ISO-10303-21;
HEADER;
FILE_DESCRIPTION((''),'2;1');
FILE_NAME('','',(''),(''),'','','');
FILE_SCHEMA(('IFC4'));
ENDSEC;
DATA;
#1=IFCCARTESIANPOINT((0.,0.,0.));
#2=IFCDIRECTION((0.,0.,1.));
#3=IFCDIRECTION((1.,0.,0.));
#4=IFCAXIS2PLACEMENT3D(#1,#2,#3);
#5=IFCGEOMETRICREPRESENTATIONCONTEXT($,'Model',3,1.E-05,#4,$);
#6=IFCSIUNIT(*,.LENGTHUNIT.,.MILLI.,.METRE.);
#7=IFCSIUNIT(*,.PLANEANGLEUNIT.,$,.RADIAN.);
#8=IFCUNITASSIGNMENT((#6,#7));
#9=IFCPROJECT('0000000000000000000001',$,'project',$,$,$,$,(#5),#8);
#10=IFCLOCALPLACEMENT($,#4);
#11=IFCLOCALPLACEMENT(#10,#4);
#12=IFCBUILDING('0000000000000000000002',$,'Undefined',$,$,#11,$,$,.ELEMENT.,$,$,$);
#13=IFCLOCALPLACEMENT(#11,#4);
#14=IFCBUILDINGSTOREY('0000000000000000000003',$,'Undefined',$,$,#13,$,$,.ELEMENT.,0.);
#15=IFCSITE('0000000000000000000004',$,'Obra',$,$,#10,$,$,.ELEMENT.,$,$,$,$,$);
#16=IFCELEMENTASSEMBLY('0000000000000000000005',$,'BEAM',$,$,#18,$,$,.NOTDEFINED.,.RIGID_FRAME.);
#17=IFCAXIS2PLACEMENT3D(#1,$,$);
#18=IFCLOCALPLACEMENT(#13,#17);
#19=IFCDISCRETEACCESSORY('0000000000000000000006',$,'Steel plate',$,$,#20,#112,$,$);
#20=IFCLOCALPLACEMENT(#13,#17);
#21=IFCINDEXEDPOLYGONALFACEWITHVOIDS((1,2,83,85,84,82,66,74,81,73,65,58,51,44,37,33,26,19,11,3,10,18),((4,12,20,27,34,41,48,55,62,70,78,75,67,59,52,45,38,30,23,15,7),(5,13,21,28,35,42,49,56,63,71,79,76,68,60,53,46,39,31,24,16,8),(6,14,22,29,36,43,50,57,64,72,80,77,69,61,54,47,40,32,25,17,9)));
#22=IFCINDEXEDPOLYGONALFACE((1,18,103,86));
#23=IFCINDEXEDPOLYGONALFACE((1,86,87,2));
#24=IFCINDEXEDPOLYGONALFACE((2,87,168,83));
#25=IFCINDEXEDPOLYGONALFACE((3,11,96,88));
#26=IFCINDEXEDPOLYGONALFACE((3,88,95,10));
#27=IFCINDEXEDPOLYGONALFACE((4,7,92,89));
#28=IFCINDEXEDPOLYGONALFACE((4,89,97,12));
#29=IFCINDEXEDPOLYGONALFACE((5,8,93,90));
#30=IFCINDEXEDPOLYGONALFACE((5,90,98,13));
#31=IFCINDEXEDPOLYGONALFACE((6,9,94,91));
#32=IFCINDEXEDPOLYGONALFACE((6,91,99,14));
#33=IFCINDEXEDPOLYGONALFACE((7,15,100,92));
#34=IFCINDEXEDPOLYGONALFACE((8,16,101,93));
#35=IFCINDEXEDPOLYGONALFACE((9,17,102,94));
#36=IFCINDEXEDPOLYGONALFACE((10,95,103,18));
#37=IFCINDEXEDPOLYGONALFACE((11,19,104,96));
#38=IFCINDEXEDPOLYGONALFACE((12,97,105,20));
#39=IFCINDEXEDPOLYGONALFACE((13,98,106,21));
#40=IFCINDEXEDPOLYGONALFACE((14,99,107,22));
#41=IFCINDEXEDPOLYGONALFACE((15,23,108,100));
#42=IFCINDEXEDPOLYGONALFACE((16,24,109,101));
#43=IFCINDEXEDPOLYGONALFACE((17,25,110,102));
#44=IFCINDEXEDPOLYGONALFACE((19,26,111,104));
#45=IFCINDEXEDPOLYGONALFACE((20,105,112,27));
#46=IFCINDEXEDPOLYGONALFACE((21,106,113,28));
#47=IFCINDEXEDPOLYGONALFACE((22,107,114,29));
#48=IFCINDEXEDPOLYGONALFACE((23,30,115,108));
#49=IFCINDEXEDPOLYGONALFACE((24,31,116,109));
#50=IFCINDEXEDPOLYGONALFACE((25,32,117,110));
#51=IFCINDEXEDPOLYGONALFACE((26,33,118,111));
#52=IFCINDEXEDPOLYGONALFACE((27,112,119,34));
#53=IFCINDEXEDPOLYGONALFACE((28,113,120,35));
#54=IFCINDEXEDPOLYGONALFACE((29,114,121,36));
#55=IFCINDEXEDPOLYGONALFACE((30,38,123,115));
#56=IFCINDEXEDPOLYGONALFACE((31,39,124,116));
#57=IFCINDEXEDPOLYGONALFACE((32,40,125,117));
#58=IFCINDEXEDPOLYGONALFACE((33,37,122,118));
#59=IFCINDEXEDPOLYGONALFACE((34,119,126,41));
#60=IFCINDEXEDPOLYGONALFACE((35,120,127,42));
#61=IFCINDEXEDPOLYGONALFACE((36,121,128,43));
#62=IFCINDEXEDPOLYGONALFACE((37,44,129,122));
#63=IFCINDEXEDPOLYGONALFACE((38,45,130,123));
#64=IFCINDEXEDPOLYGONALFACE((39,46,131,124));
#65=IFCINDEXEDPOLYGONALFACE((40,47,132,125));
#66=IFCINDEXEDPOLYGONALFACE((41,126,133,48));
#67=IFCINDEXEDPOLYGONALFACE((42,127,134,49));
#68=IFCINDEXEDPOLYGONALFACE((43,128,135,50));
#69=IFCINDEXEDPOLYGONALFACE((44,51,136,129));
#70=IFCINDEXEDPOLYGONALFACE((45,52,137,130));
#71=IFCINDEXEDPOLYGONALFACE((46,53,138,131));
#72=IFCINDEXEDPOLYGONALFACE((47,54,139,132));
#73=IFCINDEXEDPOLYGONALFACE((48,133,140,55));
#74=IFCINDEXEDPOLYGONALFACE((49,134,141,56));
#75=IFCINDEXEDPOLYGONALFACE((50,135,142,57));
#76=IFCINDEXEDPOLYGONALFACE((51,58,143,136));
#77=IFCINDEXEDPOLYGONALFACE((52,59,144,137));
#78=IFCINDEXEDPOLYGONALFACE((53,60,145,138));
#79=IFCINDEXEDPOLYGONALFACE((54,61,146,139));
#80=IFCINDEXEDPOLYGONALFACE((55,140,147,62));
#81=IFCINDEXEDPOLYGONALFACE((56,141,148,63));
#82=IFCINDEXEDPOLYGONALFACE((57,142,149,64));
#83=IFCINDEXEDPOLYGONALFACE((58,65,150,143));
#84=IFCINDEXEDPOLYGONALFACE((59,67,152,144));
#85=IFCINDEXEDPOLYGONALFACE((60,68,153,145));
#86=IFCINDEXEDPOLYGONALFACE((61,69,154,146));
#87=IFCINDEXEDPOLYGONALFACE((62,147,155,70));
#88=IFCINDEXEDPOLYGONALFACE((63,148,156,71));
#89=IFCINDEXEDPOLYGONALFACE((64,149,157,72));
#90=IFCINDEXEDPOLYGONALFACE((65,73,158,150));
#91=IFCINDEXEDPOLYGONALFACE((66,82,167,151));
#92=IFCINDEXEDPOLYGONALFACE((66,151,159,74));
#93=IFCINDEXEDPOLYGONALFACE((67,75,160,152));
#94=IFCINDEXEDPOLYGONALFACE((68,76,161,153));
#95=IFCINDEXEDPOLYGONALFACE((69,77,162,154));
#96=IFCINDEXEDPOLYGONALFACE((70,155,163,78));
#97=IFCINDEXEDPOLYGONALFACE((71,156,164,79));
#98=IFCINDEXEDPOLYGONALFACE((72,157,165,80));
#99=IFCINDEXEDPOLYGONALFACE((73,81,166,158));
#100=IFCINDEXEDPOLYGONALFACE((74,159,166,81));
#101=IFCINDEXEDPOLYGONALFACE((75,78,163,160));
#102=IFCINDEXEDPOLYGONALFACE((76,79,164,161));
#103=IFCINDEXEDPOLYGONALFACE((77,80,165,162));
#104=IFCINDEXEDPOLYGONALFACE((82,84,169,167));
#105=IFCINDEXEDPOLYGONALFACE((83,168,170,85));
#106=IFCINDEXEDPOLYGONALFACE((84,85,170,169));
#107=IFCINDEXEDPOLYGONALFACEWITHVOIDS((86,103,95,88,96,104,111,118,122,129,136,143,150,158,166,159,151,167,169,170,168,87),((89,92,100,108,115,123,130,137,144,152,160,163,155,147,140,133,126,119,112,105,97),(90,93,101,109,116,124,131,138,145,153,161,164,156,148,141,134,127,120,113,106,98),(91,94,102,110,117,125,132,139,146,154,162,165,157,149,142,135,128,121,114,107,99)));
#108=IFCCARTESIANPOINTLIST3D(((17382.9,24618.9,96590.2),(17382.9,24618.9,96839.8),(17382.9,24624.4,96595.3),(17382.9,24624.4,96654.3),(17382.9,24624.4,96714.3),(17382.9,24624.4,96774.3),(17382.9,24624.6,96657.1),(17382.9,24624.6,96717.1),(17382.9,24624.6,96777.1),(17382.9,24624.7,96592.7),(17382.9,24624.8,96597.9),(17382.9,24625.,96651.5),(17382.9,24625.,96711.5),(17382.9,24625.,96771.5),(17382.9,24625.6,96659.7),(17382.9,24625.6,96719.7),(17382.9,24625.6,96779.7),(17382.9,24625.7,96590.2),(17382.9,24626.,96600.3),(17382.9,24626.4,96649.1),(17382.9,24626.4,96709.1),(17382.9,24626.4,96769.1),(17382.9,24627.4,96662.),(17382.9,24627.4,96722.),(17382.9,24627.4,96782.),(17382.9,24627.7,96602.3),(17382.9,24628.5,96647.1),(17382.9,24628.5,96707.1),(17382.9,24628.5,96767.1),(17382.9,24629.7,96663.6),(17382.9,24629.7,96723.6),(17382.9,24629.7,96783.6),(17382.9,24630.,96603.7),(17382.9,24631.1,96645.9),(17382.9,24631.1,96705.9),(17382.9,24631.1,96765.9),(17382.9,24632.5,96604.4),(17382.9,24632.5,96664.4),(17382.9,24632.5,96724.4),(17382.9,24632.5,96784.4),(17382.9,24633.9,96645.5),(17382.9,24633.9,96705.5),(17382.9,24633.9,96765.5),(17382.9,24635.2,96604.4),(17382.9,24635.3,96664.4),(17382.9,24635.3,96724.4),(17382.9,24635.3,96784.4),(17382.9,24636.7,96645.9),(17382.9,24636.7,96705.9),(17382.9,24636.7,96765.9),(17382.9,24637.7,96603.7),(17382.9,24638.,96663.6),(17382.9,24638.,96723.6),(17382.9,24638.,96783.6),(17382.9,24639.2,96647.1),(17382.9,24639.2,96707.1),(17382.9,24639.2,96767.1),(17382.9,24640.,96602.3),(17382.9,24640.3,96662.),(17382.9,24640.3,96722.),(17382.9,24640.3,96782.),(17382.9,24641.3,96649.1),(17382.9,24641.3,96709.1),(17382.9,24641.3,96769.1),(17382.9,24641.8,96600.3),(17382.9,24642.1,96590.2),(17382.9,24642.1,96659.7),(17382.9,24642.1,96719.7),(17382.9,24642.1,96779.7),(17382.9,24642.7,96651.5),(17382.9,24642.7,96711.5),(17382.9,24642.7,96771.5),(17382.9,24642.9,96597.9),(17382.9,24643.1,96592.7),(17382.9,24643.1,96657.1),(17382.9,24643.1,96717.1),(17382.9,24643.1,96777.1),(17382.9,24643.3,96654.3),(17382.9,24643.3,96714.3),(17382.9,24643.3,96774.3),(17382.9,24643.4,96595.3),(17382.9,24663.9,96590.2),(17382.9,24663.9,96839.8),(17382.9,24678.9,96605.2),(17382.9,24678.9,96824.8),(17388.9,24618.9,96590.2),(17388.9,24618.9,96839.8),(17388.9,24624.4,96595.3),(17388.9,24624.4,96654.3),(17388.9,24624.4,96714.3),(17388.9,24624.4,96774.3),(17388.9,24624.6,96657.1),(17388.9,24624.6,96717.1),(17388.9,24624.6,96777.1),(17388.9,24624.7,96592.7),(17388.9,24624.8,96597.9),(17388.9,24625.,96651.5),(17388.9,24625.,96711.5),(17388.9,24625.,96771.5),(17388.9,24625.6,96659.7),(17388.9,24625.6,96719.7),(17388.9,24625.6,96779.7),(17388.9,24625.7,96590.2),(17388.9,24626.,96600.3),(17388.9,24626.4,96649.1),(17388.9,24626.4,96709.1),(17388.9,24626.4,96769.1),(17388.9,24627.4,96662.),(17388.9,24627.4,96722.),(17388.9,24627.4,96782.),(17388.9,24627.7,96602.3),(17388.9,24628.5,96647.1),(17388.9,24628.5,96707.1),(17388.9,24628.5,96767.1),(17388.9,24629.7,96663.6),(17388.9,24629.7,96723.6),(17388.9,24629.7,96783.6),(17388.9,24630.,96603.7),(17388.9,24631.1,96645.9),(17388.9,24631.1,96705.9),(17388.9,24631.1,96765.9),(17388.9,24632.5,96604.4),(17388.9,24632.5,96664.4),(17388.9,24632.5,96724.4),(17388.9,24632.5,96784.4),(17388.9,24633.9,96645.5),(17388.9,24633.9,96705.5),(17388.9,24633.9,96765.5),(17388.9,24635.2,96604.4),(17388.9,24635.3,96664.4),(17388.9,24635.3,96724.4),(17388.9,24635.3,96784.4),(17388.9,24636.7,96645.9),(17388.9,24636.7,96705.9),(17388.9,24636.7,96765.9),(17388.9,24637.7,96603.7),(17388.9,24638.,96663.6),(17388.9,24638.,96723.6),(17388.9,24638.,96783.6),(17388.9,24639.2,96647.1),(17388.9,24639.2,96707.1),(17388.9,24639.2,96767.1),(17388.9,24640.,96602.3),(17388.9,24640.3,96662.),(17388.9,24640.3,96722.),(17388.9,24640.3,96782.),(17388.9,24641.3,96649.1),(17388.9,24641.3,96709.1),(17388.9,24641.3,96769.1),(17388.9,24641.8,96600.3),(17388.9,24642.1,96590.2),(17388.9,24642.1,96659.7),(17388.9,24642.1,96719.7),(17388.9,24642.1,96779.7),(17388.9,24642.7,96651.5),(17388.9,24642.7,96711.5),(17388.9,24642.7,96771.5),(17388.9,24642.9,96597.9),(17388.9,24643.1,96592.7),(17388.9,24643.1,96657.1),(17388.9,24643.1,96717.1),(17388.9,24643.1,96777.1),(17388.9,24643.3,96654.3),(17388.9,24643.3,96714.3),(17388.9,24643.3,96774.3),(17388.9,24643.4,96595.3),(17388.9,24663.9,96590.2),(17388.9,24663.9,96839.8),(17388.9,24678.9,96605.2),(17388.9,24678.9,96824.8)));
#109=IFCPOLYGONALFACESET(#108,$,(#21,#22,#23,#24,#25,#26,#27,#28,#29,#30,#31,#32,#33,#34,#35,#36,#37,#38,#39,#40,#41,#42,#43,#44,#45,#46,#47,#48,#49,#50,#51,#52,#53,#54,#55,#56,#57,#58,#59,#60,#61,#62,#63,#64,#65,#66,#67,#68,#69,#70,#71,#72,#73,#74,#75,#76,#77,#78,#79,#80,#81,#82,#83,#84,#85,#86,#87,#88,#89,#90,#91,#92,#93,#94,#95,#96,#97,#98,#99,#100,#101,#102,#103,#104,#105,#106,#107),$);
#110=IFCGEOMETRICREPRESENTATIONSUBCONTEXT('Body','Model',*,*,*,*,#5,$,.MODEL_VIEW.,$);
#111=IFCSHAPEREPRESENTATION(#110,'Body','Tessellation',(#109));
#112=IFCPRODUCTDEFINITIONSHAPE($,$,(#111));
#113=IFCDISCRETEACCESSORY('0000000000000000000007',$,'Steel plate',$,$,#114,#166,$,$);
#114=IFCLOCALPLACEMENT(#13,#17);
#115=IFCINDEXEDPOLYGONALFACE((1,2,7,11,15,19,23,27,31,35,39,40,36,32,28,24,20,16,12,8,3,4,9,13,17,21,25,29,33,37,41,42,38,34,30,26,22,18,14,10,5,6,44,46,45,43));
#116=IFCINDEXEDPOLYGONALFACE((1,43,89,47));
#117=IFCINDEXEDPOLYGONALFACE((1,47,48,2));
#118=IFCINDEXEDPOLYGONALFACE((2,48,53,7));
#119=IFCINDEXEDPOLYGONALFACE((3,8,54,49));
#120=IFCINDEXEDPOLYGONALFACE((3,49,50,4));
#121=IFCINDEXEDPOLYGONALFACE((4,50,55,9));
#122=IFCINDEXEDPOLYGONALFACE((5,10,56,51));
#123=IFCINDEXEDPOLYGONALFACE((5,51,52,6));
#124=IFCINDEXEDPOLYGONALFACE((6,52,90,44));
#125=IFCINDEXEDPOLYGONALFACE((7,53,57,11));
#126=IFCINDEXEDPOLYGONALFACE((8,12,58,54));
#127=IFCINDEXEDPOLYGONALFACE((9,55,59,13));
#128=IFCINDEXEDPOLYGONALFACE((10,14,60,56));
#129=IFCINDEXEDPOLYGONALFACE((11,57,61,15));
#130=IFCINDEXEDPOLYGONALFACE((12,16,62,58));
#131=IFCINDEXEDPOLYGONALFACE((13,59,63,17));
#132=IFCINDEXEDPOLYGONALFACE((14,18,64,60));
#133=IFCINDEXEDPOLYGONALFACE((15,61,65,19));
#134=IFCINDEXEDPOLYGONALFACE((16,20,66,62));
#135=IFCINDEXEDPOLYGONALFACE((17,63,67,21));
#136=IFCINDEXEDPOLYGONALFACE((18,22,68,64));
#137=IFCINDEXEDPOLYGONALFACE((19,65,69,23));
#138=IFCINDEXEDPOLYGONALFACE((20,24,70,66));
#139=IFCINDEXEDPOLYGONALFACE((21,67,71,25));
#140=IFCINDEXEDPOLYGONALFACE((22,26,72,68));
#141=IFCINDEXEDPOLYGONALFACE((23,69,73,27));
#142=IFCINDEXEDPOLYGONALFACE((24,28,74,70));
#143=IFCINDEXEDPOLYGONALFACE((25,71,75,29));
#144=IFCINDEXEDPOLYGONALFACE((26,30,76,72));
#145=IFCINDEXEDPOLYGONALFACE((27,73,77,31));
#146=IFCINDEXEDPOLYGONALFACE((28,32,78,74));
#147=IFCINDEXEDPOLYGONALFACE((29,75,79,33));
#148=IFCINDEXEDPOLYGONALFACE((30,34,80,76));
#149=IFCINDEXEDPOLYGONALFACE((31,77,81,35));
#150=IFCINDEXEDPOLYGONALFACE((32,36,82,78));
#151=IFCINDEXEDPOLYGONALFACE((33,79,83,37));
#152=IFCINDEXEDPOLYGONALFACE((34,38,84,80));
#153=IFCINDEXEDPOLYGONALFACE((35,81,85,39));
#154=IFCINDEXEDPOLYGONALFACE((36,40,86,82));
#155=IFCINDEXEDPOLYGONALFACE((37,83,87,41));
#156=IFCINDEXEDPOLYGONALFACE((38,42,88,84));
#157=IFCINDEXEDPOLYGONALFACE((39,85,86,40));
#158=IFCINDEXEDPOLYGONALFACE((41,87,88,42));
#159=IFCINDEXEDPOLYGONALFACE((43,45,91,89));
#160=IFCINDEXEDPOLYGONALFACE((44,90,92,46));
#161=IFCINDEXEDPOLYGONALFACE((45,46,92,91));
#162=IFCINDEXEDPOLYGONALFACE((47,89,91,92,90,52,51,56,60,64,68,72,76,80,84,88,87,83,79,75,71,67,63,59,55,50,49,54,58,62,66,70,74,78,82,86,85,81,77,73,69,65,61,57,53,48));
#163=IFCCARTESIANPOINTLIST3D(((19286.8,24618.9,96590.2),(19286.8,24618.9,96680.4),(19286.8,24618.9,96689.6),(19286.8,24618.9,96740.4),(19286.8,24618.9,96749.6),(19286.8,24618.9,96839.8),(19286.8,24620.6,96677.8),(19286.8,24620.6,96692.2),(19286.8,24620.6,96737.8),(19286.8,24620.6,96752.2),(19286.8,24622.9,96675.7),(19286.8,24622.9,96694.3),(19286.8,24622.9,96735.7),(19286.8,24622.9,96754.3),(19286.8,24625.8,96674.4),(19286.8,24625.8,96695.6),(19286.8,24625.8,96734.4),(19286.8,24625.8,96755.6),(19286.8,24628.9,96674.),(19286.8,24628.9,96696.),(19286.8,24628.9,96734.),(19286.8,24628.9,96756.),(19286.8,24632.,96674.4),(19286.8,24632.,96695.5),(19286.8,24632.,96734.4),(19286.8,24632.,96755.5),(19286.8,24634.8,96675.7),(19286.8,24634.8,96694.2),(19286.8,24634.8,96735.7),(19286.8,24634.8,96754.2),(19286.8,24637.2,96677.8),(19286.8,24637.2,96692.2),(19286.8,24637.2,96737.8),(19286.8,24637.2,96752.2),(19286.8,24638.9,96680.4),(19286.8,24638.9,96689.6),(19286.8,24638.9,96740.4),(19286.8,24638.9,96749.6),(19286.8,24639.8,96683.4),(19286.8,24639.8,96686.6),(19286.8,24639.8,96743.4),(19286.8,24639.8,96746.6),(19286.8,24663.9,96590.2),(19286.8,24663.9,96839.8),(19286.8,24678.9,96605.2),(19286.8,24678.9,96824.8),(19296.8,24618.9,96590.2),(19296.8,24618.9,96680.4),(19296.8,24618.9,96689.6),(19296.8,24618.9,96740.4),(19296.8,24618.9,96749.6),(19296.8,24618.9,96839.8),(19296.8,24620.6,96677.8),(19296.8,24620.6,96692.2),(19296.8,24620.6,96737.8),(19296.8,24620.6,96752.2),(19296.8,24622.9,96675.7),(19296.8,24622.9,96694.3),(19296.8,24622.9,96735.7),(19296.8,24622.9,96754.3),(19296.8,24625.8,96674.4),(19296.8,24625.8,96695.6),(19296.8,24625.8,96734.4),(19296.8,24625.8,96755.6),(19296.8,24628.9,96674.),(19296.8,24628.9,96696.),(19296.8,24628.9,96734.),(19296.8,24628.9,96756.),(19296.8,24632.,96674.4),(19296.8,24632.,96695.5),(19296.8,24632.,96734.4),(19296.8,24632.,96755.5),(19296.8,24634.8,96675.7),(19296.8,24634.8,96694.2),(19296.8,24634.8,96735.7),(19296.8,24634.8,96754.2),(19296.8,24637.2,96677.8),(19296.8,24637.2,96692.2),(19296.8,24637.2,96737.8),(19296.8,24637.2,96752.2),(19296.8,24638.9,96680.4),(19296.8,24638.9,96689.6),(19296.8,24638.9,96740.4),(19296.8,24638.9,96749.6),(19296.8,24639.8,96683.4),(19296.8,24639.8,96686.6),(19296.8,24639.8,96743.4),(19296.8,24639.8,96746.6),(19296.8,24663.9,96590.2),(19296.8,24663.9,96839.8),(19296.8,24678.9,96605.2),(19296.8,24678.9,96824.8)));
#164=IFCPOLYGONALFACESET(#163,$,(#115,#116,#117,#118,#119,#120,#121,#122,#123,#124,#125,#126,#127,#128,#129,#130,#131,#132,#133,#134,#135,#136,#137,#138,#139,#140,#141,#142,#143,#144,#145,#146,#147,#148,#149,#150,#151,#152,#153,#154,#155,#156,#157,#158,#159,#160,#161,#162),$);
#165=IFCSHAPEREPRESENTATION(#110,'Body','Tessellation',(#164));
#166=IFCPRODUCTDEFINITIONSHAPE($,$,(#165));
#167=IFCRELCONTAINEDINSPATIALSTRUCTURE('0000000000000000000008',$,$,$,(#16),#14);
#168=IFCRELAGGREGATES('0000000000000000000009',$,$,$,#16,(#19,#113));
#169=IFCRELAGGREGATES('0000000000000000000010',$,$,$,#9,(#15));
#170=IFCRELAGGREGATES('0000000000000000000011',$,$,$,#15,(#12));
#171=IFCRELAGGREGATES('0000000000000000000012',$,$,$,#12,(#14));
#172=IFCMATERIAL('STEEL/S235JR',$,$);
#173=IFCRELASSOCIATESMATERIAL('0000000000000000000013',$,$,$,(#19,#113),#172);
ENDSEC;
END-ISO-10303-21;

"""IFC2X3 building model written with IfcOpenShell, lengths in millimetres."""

from ifc_helpers import new_model, si_unit, frame, origin_with_axes, origin_2d_with_axis, place, context, subcontext, project, spatial, polyline, circle, outline, extrude, source, transform, mapped, material, element, aggregate, save


model = new_model("IFC2X3")

# Units and contexts
model_context = context("Model", 3, precision=1e-05, world=origin_with_axes())
body_context = subcontext(model_context, "Body", "Model", "MODEL_VIEW")
ifc_project = project(units=[si_unit("LENGTHUNIT", "METRE", prefix="MILLI"), si_unit("PLANEANGLEUNIT", "RADIAN")], contexts=[model_context])

# Site, building, storey
site_placement = place(None, origin_with_axes())
site = spatial("IfcSite", under=ifc_project, at=site_placement, Name="Obra", CompositionType="ELEMENT")
building_placement = place(site_placement, origin_with_axes())
building = spatial("IfcBuilding", under=site, at=building_placement, Name="Undefined", CompositionType="ELEMENT")
storey_placement = place(building_placement, origin_with_axes())
storey = spatial("IfcBuildingStorey", under=building, at=storey_placement, Name="Undefined", CompositionType="ELEMENT", Elevation=0.0)

# Shared definitions
ifc_material = material(Name="STEEL/S235JR")

# Shared definitions
shared_shape_1 = source(origin_with_axes(), body_context, "Body", "SweptSolid", [
    extrude(circle(Radius=11.0, at=origin_2d_with_axis()), frame((0.0, -13.4, 0.0), z_axis=(0.0, 1.0, 0.0), x_axis=(1.0, 0.0, 0.0)), (0.0, 0.0, 1.0), 10.2),
])

# Element assembly, discrete accessories, openings
assembly_1_placement = place(storey_placement, origin_with_axes())
assembly_1 = element("IfcElementAssembly", 1, at=assembly_1_placement, inside=storey, Name="BEAM", AssemblyPlace="NOTDEFINED", PredefinedType="RIGID_FRAME")
discrete_accessory_1_placement = place(assembly_1_placement, frame((17385.9, 24618.9, 96590.2), z_axis=(1.0, 0.000001, 0.0), x_axis=(-0.000002, 1.0, 0.0)))
discrete_accessory_1 = element("IfcDiscreteAccessory", 2, at=discrete_accessory_1_placement, material=ifc_material, Name="Steel plate", context=body_context, shape_type="SweptSolid", body=[
    extrude(outline(polyline([(0.0, 0.0), (45.0, 0.0), (60.0, 15.0), (60.0, 234.6), (45.0, 249.6), (0.0, 249.6), (0.0, 0.0)])), frame((0.0, 0.0, -3.0), z_axis=(0.0, 0.0, 1.0), x_axis=(1.0, 0.0, 0.0)), (0.0, 0.0, 1.0), 6.0),
])
shared_shape_2 = source(origin_with_axes(), body_context, "Body", "SweptSolid", [
    extrude(circle(Radius=9.5, at=origin_2d_with_axis()), frame((0.0, -9.8, 0.0), z_axis=(0.0, 1.0, 0.0), x_axis=(1.0, 0.0, 0.0)), (0.0, 0.0, 1.0), 6.2),
])
opening_1_placement = place(assembly_1_placement, frame((17392.7, 24668.9, 96850.0), z_axis=(0.000002, -1.0, 0.0), x_axis=(0.0, 0.0, -1.0)))
element("IfcOpeningElement", 3, at=opening_1_placement, cuts=discrete_accessory_1, ObjectType="Opening", context=body_context, shape_type="MappedRepresentation", body=[
    mapped(shared_shape_2, transform((75.0, 0.0, 35.0))),
    mapped(shared_shape_2, transform((135.0, 0.0, 35.0))),
    mapped(shared_shape_2, transform((195.0, 0.0, 35.0))),
    mapped(shared_shape_2, transform((255.0, 0.0, 35.0))),
])
discrete_accessory_2_placement = place(assembly_1_placement, frame((19291.8, 24618.9, 96590.2), z_axis=(1.0, 0.000001, 0.0), x_axis=(-0.000002, 1.0, 0.0)))
discrete_accessory_2 = element("IfcDiscreteAccessory", 4, at=discrete_accessory_2_placement, material=ifc_material, Name="Steel plate", context=body_context, shape_type="SweptSolid", body=[
    extrude(outline(polyline([(0.0, 0.0), (45.0, 0.0), (60.0, 15.0), (60.0, 234.6), (45.0, 249.6), (0.0, 249.6), (0.0, 0.0)])), frame((0.0, 0.0, -5.0), z_axis=(0.0, 0.0, 1.0), x_axis=(1.0, 0.0, 0.0)), (0.0, 0.0, 1.0), 10.0),
])
opening_2_placement = place(assembly_1_placement, frame((19300.1, 24668.9, 96850.0), z_axis=(0.000002, -1.0, 0.0), x_axis=(0.0, 0.0, -1.0)))
element("IfcOpeningElement", 5, at=opening_2_placement, cuts=discrete_accessory_2, ObjectType="Opening", context=body_context, shape_type="MappedRepresentation", body=[
    mapped(shared_shape_1, transform((105.0, 0.0, 40.0))),
    mapped(shared_shape_1, transform((165.0, 0.0, 40.0))),
])
aggregate(assembly_1, [discrete_accessory_1, discrete_accessory_2])

save(model, "model.ifc")
